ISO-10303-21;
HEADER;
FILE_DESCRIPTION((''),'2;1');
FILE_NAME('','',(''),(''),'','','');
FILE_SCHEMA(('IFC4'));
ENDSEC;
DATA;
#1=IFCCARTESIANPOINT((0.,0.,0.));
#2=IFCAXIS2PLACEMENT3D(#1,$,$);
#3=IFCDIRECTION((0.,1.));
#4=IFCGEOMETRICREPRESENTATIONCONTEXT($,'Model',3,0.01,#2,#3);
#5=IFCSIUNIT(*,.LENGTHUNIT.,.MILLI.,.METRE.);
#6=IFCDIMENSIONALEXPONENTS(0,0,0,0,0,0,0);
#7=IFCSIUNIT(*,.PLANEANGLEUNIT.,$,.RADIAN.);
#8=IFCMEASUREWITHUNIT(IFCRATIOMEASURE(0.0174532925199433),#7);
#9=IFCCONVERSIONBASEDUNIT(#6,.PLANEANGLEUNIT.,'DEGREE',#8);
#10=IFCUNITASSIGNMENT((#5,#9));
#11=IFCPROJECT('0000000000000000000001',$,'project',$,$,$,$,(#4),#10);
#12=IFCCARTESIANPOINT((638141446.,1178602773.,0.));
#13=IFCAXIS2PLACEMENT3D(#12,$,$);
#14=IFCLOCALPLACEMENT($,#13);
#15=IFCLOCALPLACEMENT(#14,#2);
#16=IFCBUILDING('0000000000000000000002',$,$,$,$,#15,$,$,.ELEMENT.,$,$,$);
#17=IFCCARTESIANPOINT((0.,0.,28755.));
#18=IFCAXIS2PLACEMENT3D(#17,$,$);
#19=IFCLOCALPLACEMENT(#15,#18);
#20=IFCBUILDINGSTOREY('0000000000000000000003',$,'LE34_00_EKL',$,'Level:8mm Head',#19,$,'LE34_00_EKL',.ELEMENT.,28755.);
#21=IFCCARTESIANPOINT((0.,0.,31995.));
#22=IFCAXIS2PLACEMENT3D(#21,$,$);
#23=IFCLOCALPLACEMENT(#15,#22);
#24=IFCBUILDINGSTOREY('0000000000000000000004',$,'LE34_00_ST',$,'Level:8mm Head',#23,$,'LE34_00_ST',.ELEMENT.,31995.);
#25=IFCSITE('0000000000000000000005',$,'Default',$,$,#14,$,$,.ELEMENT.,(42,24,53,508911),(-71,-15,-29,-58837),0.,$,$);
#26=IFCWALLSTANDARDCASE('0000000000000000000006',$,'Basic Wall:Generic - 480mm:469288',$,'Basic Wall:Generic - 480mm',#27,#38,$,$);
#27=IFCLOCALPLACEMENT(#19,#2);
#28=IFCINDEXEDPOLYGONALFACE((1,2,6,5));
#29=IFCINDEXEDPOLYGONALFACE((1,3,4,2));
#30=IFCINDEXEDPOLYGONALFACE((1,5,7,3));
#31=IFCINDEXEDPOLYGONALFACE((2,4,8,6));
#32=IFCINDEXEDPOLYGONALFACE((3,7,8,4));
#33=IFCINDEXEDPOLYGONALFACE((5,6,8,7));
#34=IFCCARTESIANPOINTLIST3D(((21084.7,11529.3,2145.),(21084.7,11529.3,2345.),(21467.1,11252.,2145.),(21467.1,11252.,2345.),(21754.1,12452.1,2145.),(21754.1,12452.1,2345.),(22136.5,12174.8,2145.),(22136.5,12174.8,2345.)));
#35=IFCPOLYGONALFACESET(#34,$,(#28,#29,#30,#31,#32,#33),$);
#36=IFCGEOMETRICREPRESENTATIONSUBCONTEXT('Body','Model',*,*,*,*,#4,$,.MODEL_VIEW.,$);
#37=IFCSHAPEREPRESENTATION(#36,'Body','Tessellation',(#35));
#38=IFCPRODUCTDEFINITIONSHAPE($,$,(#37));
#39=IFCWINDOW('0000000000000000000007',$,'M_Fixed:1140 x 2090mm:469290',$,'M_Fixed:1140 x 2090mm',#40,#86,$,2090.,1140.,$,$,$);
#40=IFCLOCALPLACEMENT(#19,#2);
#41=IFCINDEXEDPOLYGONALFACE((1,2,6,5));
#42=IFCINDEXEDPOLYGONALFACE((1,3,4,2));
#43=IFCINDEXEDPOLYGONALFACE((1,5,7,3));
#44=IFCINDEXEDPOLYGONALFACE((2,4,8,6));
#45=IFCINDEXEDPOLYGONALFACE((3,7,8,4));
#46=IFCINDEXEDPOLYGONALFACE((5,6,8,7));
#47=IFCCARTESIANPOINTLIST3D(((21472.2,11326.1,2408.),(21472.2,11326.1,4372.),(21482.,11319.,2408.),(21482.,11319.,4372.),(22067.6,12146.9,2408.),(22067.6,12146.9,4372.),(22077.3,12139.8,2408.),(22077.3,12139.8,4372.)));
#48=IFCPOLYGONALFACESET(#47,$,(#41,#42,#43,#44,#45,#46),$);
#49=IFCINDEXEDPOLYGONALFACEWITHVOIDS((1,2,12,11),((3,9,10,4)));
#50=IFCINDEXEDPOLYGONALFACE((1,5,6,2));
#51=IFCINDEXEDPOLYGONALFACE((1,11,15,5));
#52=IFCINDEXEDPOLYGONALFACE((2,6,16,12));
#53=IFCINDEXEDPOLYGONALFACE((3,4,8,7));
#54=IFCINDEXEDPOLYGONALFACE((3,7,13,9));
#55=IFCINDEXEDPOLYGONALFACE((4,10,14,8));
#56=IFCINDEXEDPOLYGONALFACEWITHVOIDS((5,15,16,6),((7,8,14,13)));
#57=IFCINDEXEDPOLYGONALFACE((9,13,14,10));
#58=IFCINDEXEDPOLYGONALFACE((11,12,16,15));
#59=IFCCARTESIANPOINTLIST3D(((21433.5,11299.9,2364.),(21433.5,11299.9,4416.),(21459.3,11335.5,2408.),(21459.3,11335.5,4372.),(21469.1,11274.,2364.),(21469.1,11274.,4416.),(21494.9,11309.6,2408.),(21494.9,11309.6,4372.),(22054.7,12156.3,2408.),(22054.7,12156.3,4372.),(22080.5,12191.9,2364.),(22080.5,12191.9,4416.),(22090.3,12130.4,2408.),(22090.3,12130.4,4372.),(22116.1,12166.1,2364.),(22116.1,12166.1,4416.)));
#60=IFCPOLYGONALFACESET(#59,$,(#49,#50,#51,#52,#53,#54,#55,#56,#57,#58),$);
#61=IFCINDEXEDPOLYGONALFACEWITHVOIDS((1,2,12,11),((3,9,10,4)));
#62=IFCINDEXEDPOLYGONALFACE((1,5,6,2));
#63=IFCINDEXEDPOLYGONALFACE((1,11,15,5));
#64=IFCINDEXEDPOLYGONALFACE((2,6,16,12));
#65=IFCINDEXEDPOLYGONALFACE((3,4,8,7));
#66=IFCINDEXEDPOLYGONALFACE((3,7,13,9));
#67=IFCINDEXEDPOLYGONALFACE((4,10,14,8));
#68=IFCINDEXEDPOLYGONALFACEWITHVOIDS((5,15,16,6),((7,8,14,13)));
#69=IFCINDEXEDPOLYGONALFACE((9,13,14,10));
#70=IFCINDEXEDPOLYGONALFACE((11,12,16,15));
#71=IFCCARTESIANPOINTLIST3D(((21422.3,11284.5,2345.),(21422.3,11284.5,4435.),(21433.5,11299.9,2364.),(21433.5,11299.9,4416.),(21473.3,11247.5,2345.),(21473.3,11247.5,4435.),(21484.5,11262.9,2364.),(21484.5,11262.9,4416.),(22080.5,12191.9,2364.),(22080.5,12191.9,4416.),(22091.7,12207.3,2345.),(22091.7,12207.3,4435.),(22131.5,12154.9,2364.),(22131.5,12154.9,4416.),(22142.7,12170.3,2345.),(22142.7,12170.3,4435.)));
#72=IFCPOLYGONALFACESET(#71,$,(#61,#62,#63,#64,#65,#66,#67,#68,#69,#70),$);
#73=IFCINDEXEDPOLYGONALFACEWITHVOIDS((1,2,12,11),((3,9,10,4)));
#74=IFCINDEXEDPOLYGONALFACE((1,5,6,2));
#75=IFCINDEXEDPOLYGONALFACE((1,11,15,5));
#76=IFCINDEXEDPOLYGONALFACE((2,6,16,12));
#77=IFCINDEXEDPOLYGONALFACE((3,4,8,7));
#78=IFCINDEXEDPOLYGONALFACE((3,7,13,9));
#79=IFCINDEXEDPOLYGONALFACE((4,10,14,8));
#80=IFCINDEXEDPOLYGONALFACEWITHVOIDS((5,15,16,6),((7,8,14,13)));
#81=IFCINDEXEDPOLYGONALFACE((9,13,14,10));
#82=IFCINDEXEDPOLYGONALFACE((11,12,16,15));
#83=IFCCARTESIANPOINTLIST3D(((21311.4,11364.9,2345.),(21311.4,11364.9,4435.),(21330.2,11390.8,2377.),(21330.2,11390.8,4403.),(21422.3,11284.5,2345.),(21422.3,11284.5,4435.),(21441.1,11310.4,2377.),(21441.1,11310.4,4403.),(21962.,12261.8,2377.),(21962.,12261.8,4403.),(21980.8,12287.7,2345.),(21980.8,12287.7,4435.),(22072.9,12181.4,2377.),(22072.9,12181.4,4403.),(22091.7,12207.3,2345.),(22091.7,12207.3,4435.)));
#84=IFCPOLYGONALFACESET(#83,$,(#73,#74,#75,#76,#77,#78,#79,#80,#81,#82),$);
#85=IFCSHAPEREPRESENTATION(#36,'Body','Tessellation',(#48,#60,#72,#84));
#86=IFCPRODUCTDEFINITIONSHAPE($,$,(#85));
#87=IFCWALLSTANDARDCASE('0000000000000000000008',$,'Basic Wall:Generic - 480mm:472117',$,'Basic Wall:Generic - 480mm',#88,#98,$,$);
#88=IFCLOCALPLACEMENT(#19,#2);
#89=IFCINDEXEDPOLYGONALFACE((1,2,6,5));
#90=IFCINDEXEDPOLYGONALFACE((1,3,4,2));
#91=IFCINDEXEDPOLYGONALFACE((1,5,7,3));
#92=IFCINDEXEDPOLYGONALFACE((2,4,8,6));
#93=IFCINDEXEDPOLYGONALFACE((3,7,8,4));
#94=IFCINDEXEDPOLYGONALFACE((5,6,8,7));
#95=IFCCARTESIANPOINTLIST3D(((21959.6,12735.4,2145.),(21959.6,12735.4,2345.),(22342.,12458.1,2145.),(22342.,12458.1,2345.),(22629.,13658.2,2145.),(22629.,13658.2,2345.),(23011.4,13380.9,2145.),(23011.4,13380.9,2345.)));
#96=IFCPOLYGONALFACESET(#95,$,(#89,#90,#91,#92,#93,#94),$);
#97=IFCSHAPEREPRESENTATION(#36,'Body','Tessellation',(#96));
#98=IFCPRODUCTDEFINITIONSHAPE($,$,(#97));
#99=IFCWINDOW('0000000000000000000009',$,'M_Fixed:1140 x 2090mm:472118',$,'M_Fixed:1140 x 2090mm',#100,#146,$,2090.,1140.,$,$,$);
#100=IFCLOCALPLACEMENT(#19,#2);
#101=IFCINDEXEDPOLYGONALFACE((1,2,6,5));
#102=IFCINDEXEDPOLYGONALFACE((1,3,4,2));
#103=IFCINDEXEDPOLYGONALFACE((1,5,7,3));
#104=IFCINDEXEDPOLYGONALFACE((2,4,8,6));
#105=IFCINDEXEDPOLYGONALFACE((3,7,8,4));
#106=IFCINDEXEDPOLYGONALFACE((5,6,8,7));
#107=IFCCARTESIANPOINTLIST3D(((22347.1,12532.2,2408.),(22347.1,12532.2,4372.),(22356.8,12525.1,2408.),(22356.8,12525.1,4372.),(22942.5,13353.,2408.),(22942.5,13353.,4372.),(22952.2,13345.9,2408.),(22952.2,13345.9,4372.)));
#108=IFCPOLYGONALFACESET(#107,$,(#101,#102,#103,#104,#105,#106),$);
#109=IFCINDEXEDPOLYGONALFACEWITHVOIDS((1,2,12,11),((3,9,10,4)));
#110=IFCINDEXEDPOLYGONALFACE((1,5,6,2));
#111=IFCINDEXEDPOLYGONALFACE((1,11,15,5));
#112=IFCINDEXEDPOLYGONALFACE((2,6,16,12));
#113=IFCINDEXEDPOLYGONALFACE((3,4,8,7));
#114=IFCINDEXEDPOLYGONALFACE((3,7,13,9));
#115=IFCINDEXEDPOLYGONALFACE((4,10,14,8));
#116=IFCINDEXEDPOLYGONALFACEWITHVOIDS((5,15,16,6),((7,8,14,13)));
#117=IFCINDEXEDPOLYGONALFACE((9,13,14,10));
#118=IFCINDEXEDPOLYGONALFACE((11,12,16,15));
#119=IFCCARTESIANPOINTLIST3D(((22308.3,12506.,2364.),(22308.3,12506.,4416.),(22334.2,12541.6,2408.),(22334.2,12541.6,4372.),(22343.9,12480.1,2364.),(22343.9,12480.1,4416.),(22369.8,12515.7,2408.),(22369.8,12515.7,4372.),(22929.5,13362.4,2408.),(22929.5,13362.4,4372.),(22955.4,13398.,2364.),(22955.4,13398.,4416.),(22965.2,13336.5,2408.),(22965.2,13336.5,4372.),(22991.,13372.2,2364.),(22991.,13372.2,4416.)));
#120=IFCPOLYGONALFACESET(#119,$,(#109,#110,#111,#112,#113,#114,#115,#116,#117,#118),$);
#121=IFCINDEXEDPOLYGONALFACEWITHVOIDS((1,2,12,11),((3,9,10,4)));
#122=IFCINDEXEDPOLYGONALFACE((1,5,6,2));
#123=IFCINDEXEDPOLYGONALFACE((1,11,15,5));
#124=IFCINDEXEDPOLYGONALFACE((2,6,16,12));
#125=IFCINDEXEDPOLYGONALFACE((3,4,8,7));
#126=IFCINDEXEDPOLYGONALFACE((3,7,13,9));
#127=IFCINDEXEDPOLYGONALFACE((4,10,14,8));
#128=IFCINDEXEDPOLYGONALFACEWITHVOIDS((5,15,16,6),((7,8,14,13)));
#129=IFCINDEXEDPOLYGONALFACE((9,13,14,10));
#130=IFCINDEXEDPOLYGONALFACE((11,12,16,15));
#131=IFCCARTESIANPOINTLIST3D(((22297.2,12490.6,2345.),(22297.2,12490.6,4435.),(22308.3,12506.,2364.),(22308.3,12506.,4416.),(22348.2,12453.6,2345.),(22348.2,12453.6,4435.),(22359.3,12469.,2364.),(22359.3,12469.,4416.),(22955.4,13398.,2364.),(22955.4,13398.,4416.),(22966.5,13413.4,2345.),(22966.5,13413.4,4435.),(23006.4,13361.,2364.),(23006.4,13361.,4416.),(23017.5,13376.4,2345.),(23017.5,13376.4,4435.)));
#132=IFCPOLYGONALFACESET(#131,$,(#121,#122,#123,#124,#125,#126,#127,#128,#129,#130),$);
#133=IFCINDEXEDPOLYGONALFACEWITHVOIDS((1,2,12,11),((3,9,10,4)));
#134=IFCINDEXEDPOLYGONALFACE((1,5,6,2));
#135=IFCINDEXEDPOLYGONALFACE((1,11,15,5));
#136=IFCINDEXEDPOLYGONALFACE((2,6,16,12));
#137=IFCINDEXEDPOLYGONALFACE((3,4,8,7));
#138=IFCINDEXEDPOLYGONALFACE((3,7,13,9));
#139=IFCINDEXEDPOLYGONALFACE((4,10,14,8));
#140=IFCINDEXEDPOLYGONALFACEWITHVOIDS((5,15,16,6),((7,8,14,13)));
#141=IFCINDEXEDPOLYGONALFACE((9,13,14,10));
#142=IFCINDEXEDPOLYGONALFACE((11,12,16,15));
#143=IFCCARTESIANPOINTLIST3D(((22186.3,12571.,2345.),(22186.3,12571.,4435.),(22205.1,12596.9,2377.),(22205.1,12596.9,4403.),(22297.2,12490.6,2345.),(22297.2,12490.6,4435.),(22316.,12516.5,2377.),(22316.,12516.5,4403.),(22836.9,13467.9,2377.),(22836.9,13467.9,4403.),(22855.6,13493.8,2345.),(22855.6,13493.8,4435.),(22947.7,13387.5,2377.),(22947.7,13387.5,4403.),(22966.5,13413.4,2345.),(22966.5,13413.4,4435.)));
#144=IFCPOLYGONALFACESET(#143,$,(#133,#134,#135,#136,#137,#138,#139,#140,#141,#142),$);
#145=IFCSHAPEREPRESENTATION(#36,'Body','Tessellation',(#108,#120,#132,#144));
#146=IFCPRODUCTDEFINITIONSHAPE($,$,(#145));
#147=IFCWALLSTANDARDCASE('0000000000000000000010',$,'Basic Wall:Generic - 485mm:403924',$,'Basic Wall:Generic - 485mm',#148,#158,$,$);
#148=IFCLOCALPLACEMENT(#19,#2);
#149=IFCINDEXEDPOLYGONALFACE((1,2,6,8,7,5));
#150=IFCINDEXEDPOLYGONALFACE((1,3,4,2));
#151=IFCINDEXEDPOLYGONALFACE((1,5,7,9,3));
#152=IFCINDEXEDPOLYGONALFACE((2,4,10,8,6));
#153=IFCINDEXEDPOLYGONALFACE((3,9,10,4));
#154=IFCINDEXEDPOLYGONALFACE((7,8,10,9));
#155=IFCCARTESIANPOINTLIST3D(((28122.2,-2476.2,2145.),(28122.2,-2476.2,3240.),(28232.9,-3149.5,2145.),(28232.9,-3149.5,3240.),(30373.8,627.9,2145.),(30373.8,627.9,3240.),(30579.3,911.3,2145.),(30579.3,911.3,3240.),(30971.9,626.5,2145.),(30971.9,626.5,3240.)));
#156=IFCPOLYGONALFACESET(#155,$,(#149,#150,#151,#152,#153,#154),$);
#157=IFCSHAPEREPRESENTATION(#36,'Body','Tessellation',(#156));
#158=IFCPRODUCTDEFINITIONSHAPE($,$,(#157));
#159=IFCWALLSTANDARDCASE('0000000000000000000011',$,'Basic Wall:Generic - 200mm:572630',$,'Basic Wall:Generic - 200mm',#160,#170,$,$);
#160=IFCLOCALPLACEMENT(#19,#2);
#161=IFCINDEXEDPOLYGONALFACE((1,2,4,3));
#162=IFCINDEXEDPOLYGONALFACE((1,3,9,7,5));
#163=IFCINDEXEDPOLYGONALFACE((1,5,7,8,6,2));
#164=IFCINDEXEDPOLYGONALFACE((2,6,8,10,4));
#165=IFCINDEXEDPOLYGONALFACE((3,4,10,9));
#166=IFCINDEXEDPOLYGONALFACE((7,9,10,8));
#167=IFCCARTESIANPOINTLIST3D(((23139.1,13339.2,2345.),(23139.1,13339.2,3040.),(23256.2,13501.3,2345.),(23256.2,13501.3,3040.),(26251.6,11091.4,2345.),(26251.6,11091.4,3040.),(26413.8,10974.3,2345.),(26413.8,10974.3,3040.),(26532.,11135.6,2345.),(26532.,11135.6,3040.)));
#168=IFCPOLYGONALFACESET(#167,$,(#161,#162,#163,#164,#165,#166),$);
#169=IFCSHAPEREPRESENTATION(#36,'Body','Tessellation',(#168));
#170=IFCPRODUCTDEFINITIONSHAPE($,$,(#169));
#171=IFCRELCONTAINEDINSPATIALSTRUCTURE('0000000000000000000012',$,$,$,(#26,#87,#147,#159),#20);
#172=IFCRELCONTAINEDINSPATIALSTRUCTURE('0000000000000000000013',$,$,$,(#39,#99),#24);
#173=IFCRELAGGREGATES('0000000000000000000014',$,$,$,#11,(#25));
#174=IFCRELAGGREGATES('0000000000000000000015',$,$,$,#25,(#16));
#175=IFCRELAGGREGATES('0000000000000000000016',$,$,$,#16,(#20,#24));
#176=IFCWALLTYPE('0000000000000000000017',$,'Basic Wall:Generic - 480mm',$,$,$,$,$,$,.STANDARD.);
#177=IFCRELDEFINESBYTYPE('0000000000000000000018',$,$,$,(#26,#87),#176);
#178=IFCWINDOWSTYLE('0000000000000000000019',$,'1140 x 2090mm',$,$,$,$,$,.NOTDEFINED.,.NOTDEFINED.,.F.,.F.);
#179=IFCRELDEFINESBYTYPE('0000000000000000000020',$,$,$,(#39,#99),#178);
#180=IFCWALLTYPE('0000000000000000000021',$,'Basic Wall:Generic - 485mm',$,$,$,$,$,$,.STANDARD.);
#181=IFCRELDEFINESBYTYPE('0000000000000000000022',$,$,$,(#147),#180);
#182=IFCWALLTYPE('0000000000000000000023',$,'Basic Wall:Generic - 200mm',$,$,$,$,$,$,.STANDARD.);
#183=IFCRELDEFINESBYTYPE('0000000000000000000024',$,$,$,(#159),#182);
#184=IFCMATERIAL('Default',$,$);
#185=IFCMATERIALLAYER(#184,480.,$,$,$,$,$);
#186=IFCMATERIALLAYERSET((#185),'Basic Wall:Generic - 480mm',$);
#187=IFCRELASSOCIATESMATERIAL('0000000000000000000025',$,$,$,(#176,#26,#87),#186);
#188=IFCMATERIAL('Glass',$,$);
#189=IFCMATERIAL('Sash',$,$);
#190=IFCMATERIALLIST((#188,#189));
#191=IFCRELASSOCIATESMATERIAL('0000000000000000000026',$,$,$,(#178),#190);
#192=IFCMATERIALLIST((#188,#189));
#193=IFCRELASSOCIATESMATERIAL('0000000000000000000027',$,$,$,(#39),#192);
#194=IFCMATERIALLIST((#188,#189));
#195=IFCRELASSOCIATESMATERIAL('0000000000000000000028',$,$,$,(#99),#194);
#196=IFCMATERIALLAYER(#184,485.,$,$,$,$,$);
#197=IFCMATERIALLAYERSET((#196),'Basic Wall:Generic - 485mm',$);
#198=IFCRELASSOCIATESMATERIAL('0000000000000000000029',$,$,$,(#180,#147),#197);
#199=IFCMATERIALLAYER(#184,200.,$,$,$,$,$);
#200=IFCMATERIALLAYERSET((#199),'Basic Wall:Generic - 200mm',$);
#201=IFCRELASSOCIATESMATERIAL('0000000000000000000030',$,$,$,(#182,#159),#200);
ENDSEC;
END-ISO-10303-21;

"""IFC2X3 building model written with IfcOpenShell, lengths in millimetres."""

from ifc_helpers import new_model, entity, si_unit, converted_unit, direction, frame, frame_2d, origin, origin_2d_with_axis, place, context, subcontext, project, spatial, polyline, rectangle, outline, extrude, clip, bounded_halfspace, source, transform, mapped, material, material_list, layer, layer_set, layer_usage, type_object, type_shapes, element, fill, save


model = new_model("IFC2X3")

# Units and contexts
model_context = context("Model", 3, precision=0.01, world=origin(), true_north=direction((0.0, 1.0)))
body_context = subcontext(model_context, "Body", "Model", "MODEL_VIEW")
ifc_project = project(units=[si_unit("LENGTHUNIT", "METRE", prefix="MILLI"), converted_unit("PLANEANGLEUNIT", "DEGREE", entity("IfcRatioMeasure", 0.0174532925199433), si_unit("PLANEANGLEUNIT", "RADIAN"), dimensions=[0, 0, 0, 0, 0, 0, 0])], contexts=[model_context])

# Site, building, storey
site_placement = place(None, frame((638141446.0, 1178602773.0, 0.0)))
site = spatial("IfcSite", under=ifc_project, at=site_placement, Name="Default", CompositionType="ELEMENT", RefLatitude=(42, 24, 53, 508911), RefLongitude=(-71, -15, -29, -58837), RefElevation=0.0)
building_placement = place(site_placement, origin())
building = spatial("IfcBuilding", under=site, at=building_placement, CompositionType="ELEMENT")
storey_1_placement = place(building_placement, frame((0.0, 0.0, 28755.0)))
storey_1 = spatial("IfcBuildingStorey", under=building, at=storey_1_placement, Name="LE34_00_EKL", ObjectType="Level:8mm Head", LongName="LE34_00_EKL", CompositionType="ELEMENT", Elevation=28755.0)

# Wall, opening
ifc_material_1 = material(Name="Default")
ifc_layer_1 = layer(ifc_material_1, 480.0)
ifc_layer_set_1 = layer_set([ifc_layer_1], Name="Basic Wall:Generic - 480mm")
wall_type_1 = type_object("IfcWallType", Name="Basic Wall:Generic - 480mm", PredefinedType="STANDARD", material=ifc_layer_set_1)
ifc_layer_usage_1 = layer_usage(ifc_layer_set_1, "AXIS2", "NEGATIVE", 240.0)
wall_1_placement = place(storey_1_placement, frame((21279.0, 11388.4, 2145.0), z_axis=(0.0, 0.0, 1.0), x_axis=(0.587164, 0.809468, 0.0)))
wall_1 = element("IfcWallStandardCase", 1, at=wall_1_placement, inside=storey_1, type_object=wall_type_1, material=ifc_layer_usage_1, Name="Basic Wall:Generic - 480mm:469288", ObjectType="Basic Wall:Generic - 480mm", context=body_context, shape_type="Clipping", body=[
    clip(extrude(rectangle(XDim=1140.0, YDim=480.0, at=frame_2d((570.0, 0.0), x_axis=(-1.0, 0.0))), origin(), (0.0, 0.0, 1.0), 200.0), bounded_halfspace(frame((0.0, -232.4, 0.0), z_axis=(0.0, 1.0, 0.0), x_axis=(0.0, 0.0, 1.0)), True, frame((0.0, -232.4, 0.0), z_axis=(0.0, 1.0, 0.0), x_axis=(0.0, 0.0, 1.0)), polyline([(0.0, 0.0), (200.0, 0.0), (200.0, 1140.0), (0.0, 1140.0), (0.0, 0.0)]))),
])
opening_1_placement = place(wall_1_placement, frame((1140.0, 240.0, 200.0)))
opening_1 = element("IfcOpeningElement", 2, at=opening_1_placement, cuts=wall_1, ObjectType="Opening", context=body_context, shape_type="SweptSolid", body=[
    extrude(rectangle(XDim=2090.0, YDim=1140.0, at=frame_2d((1045.0, 570.0), x_axis=(1.0, 0.0))), frame((0.0, 0.0, 0.0), z_axis=(0.0, -1.0, 0.0), x_axis=(0.0, 0.0, 1.0)), (0.0, 0.0, 1.0), 480.0),
])

# Shared definitions
storey_2_placement = place(building_placement, frame((0.0, 0.0, 31995.0)))
storey_2 = spatial("IfcBuildingStorey", under=building, at=storey_2_placement, Name="LE34_00_ST", ObjectType="Level:8mm Head", LongName="LE34_00_ST", CompositionType="ELEMENT", Elevation=31995.0)

# Window
ifc_material_2 = material(Name="Glass")
ifc_material_3 = material(Name="Sash")
ifc_material_list_1 = material_list([ifc_material_2, ifc_material_3])
ifc_material_list_2 = material_list([ifc_material_2, ifc_material_3])
window_style = type_object("IfcWindowStyle", Name="1140 x 2090mm", ConstructionType="NOTDEFINED", OperationType="NOTDEFINED", ParameterTakesPrecedence=False, Sizeable=False, material=ifc_material_list_2)
shared_shape_1 = source(origin(), body_context, "Body", "SweptSolid", [
    extrude(rectangle(XDim=12.0, YDim=1014.0, at=origin_2d_with_axis()), frame((570.0, 439.0, 63.0), z_axis=(0.0, 0.0, 1.0), x_axis=(0.0, -1.0, 0.0)), (0.0, 0.0, 1.0), 1964.0),
    extrude(outline(polyline([(-551.0, -1026.0), (551.0, -1026.0), (551.0, 1026.0), (-551.0, 1026.0), (-551.0, -1026.0)]), holes=[polyline([(-507.0, -982.0), (-507.0, 982.0), (507.0, 982.0), (507.0, -982.0), (-507.0, -982.0)])]), frame((570.0, 417.0, 1045.0), z_axis=(0.0, 1.0, 0.0), x_axis=(1.0, 0.0, 0.0)), (0.0, 0.0, 1.0), 44.0),
    extrude(outline(polyline([(-570.0, -1045.0), (570.0, -1045.0), (570.0, 1045.0), (-570.0, 1045.0), (-570.0, -1045.0)]), holes=[polyline([(-551.0, -1026.0), (-551.0, 1026.0), (551.0, 1026.0), (551.0, -1026.0), (-551.0, -1026.0)])]), frame((570.0, 417.0, 1045.0), z_axis=(0.0, 1.0, 0.0), x_axis=(1.0, 0.0, 0.0)), (0.0, 0.0, 1.0), 63.0),
    extrude(outline(polyline([(-570.0, -1045.0), (570.0, -1045.0), (570.0, 1045.0), (-570.0, 1045.0), (-570.0, -1045.0)]), holes=[polyline([(-538.0, -1013.0), (-538.0, 1013.0), (538.0, 1013.0), (538.0, -1013.0), (-538.0, -1013.0)])]), frame((570.0, 280.0, 1045.0), z_axis=(0.0, 1.0, 0.0), x_axis=(1.0, 0.0, 0.0)), (0.0, 0.0, 1.0), 137.0),
])
type_shapes(window_style, [shared_shape_1])
window_1_placement = place(opening_1_placement, frame((0.0, 0.0, 0.0), z_axis=(0.0, 0.0, 1.0), x_axis=(-1.0, 0.0, 0.0)))
window_1 = element("IfcWindow", 3, at=window_1_placement, inside=storey_2, type_object=window_style, material=ifc_material_list_1, Name="M_Fixed:1140 x 2090mm:469290", ObjectType="M_Fixed:1140 x 2090mm", OverallHeight=2090.0, OverallWidth=1140.0, context=body_context, shape_type="MappedRepresentation", body=[
    mapped(shared_shape_1, transform((0.0, 0.0, 0.0), scale=1.0)),
])
fill(opening_1, window_1)

# Wall, opening, window
ifc_layer_usage_2 = layer_usage(ifc_layer_set_1, "AXIS2", "NEGATIVE", 240.0)
wall_2_placement = place(storey_1_placement, frame((22153.9, 12594.5, 2145.0), z_axis=(0.0, 0.0, 1.0), x_axis=(0.587164, 0.809468, 0.0)))
wall_2 = element("IfcWallStandardCase", 4, at=wall_2_placement, inside=storey_1, type_object=wall_type_1, material=ifc_layer_usage_2, Name="Basic Wall:Generic - 480mm:472117", ObjectType="Basic Wall:Generic - 480mm", context=body_context, shape_type="Clipping", body=[
    clip(extrude(rectangle(XDim=1140.0, YDim=480.0, at=frame_2d((570.0, 0.0), x_axis=(-1.0, 0.0))), origin(), (0.0, 0.0, 1.0), 200.0), bounded_halfspace(frame((0.0, -232.4, 0.0), z_axis=(0.0, 1.0, 0.0), x_axis=(0.0, 0.0, 1.0)), True, frame((0.0, -232.4, 0.0), z_axis=(0.0, 1.0, 0.0), x_axis=(0.0, 0.0, 1.0)), polyline([(0.0, 0.0), (200.0, 0.0), (200.0, 1140.0), (0.0, 1140.0), (0.0, 0.0)]))),
])
opening_2_placement = place(wall_2_placement, frame((1140.0, 240.0, 200.0)))
opening_2 = element("IfcOpeningElement", 5, at=opening_2_placement, cuts=wall_2, ObjectType="Opening", context=body_context, shape_type="SweptSolid", body=[
    extrude(rectangle(XDim=2090.0, YDim=1140.0, at=frame_2d((1045.0, 570.0), x_axis=(1.0, 0.0))), frame((0.0, 0.0, 0.0), z_axis=(0.0, -1.0, 0.0), x_axis=(0.0, 0.0, 1.0)), (0.0, 0.0, 1.0), 480.0),
])
ifc_material_list_3 = material_list([ifc_material_2, ifc_material_3])
window_2_placement = place(opening_2_placement, frame((0.0, 0.0, 0.0), z_axis=(0.0, 0.0, 1.0), x_axis=(-1.0, 0.0, 0.0)))
window_2 = element("IfcWindow", 6, at=window_2_placement, inside=storey_2, type_object=window_style, material=ifc_material_list_3, Name="M_Fixed:1140 x 2090mm:472118", ObjectType="M_Fixed:1140 x 2090mm", OverallHeight=2090.0, OverallWidth=1140.0, context=body_context, shape_type="MappedRepresentation", body=[
    mapped(shared_shape_1, transform((0.0, 0.0, 0.0), scale=1.0)),
])
fill(opening_2, window_2)

# Walls
ifc_layer_2 = layer(ifc_material_1, 485.0)
ifc_layer_set_2 = layer_set([ifc_layer_2], Name="Basic Wall:Generic - 485mm")
ifc_layer_usage_3 = layer_usage(ifc_layer_set_2, "AXIS2", "NEGATIVE", 242.5)
wall_type_2 = type_object("IfcWallType", Name="Basic Wall:Generic - 485mm", PredefinedType="STANDARD", material=ifc_layer_set_2)
wall_3_placement = place(storey_1_placement, frame((30775.6, 768.9, 2145.0), z_axis=(0.0, 0.0, 1.0), x_axis=(-0.587164, -0.809468, 0.0)))
element("IfcWallStandardCase", 7, at=wall_3_placement, inside=storey_1, type_object=wall_type_2, material=ifc_layer_usage_3, Name="Basic Wall:Generic - 485mm:403924", ObjectType="Basic Wall:Generic - 485mm", context=body_context, shape_type="SweptSolid", body=[
    extrude(outline(polyline([(4184.8, -242.5), (4664.8, 242.5), (0.0, 242.5), (0.0, -242.5), (350.0, -242.5), (4184.8, -242.5)])), origin(), (0.0, 0.0, 1.0), 1095.0),
])
ifc_layer_3 = layer(ifc_material_1, 200.0)
ifc_layer_set_3 = layer_set([ifc_layer_3], Name="Basic Wall:Generic - 200mm")
ifc_layer_usage_4 = layer_usage(ifc_layer_set_3, "AXIS2", "NEGATIVE", 100.0)
wall_type_3 = type_object("IfcWallType", Name="Basic Wall:Generic - 200mm", PredefinedType="STANDARD", material=ifc_layer_set_3)
wall_4_placement = place(storey_1_placement, frame((26473.4, 11054.5, 2345.0), z_axis=(0.0, 0.0, 1.0), x_axis=(-0.810698, 0.585464, 0.0)))
element("IfcWallStandardCase", 8, at=wall_4_placement, inside=storey_1, type_object=wall_type_3, material=ifc_layer_usage_4, Name="Basic Wall:Generic - 200mm:572630", ObjectType="Basic Wall:Generic - 200mm", context=body_context, shape_type="SweptSolid", body=[
    extrude(outline(polyline([(4040.7, -100.0), (4040.7, 100.0), (201.4, 100.0), (1.4, 100.0), (0.0, -100.0), (4040.7, -100.0)])), origin(), (0.0, 0.0, 1.0), 695.0),
])

save(model, "model.ifc")
